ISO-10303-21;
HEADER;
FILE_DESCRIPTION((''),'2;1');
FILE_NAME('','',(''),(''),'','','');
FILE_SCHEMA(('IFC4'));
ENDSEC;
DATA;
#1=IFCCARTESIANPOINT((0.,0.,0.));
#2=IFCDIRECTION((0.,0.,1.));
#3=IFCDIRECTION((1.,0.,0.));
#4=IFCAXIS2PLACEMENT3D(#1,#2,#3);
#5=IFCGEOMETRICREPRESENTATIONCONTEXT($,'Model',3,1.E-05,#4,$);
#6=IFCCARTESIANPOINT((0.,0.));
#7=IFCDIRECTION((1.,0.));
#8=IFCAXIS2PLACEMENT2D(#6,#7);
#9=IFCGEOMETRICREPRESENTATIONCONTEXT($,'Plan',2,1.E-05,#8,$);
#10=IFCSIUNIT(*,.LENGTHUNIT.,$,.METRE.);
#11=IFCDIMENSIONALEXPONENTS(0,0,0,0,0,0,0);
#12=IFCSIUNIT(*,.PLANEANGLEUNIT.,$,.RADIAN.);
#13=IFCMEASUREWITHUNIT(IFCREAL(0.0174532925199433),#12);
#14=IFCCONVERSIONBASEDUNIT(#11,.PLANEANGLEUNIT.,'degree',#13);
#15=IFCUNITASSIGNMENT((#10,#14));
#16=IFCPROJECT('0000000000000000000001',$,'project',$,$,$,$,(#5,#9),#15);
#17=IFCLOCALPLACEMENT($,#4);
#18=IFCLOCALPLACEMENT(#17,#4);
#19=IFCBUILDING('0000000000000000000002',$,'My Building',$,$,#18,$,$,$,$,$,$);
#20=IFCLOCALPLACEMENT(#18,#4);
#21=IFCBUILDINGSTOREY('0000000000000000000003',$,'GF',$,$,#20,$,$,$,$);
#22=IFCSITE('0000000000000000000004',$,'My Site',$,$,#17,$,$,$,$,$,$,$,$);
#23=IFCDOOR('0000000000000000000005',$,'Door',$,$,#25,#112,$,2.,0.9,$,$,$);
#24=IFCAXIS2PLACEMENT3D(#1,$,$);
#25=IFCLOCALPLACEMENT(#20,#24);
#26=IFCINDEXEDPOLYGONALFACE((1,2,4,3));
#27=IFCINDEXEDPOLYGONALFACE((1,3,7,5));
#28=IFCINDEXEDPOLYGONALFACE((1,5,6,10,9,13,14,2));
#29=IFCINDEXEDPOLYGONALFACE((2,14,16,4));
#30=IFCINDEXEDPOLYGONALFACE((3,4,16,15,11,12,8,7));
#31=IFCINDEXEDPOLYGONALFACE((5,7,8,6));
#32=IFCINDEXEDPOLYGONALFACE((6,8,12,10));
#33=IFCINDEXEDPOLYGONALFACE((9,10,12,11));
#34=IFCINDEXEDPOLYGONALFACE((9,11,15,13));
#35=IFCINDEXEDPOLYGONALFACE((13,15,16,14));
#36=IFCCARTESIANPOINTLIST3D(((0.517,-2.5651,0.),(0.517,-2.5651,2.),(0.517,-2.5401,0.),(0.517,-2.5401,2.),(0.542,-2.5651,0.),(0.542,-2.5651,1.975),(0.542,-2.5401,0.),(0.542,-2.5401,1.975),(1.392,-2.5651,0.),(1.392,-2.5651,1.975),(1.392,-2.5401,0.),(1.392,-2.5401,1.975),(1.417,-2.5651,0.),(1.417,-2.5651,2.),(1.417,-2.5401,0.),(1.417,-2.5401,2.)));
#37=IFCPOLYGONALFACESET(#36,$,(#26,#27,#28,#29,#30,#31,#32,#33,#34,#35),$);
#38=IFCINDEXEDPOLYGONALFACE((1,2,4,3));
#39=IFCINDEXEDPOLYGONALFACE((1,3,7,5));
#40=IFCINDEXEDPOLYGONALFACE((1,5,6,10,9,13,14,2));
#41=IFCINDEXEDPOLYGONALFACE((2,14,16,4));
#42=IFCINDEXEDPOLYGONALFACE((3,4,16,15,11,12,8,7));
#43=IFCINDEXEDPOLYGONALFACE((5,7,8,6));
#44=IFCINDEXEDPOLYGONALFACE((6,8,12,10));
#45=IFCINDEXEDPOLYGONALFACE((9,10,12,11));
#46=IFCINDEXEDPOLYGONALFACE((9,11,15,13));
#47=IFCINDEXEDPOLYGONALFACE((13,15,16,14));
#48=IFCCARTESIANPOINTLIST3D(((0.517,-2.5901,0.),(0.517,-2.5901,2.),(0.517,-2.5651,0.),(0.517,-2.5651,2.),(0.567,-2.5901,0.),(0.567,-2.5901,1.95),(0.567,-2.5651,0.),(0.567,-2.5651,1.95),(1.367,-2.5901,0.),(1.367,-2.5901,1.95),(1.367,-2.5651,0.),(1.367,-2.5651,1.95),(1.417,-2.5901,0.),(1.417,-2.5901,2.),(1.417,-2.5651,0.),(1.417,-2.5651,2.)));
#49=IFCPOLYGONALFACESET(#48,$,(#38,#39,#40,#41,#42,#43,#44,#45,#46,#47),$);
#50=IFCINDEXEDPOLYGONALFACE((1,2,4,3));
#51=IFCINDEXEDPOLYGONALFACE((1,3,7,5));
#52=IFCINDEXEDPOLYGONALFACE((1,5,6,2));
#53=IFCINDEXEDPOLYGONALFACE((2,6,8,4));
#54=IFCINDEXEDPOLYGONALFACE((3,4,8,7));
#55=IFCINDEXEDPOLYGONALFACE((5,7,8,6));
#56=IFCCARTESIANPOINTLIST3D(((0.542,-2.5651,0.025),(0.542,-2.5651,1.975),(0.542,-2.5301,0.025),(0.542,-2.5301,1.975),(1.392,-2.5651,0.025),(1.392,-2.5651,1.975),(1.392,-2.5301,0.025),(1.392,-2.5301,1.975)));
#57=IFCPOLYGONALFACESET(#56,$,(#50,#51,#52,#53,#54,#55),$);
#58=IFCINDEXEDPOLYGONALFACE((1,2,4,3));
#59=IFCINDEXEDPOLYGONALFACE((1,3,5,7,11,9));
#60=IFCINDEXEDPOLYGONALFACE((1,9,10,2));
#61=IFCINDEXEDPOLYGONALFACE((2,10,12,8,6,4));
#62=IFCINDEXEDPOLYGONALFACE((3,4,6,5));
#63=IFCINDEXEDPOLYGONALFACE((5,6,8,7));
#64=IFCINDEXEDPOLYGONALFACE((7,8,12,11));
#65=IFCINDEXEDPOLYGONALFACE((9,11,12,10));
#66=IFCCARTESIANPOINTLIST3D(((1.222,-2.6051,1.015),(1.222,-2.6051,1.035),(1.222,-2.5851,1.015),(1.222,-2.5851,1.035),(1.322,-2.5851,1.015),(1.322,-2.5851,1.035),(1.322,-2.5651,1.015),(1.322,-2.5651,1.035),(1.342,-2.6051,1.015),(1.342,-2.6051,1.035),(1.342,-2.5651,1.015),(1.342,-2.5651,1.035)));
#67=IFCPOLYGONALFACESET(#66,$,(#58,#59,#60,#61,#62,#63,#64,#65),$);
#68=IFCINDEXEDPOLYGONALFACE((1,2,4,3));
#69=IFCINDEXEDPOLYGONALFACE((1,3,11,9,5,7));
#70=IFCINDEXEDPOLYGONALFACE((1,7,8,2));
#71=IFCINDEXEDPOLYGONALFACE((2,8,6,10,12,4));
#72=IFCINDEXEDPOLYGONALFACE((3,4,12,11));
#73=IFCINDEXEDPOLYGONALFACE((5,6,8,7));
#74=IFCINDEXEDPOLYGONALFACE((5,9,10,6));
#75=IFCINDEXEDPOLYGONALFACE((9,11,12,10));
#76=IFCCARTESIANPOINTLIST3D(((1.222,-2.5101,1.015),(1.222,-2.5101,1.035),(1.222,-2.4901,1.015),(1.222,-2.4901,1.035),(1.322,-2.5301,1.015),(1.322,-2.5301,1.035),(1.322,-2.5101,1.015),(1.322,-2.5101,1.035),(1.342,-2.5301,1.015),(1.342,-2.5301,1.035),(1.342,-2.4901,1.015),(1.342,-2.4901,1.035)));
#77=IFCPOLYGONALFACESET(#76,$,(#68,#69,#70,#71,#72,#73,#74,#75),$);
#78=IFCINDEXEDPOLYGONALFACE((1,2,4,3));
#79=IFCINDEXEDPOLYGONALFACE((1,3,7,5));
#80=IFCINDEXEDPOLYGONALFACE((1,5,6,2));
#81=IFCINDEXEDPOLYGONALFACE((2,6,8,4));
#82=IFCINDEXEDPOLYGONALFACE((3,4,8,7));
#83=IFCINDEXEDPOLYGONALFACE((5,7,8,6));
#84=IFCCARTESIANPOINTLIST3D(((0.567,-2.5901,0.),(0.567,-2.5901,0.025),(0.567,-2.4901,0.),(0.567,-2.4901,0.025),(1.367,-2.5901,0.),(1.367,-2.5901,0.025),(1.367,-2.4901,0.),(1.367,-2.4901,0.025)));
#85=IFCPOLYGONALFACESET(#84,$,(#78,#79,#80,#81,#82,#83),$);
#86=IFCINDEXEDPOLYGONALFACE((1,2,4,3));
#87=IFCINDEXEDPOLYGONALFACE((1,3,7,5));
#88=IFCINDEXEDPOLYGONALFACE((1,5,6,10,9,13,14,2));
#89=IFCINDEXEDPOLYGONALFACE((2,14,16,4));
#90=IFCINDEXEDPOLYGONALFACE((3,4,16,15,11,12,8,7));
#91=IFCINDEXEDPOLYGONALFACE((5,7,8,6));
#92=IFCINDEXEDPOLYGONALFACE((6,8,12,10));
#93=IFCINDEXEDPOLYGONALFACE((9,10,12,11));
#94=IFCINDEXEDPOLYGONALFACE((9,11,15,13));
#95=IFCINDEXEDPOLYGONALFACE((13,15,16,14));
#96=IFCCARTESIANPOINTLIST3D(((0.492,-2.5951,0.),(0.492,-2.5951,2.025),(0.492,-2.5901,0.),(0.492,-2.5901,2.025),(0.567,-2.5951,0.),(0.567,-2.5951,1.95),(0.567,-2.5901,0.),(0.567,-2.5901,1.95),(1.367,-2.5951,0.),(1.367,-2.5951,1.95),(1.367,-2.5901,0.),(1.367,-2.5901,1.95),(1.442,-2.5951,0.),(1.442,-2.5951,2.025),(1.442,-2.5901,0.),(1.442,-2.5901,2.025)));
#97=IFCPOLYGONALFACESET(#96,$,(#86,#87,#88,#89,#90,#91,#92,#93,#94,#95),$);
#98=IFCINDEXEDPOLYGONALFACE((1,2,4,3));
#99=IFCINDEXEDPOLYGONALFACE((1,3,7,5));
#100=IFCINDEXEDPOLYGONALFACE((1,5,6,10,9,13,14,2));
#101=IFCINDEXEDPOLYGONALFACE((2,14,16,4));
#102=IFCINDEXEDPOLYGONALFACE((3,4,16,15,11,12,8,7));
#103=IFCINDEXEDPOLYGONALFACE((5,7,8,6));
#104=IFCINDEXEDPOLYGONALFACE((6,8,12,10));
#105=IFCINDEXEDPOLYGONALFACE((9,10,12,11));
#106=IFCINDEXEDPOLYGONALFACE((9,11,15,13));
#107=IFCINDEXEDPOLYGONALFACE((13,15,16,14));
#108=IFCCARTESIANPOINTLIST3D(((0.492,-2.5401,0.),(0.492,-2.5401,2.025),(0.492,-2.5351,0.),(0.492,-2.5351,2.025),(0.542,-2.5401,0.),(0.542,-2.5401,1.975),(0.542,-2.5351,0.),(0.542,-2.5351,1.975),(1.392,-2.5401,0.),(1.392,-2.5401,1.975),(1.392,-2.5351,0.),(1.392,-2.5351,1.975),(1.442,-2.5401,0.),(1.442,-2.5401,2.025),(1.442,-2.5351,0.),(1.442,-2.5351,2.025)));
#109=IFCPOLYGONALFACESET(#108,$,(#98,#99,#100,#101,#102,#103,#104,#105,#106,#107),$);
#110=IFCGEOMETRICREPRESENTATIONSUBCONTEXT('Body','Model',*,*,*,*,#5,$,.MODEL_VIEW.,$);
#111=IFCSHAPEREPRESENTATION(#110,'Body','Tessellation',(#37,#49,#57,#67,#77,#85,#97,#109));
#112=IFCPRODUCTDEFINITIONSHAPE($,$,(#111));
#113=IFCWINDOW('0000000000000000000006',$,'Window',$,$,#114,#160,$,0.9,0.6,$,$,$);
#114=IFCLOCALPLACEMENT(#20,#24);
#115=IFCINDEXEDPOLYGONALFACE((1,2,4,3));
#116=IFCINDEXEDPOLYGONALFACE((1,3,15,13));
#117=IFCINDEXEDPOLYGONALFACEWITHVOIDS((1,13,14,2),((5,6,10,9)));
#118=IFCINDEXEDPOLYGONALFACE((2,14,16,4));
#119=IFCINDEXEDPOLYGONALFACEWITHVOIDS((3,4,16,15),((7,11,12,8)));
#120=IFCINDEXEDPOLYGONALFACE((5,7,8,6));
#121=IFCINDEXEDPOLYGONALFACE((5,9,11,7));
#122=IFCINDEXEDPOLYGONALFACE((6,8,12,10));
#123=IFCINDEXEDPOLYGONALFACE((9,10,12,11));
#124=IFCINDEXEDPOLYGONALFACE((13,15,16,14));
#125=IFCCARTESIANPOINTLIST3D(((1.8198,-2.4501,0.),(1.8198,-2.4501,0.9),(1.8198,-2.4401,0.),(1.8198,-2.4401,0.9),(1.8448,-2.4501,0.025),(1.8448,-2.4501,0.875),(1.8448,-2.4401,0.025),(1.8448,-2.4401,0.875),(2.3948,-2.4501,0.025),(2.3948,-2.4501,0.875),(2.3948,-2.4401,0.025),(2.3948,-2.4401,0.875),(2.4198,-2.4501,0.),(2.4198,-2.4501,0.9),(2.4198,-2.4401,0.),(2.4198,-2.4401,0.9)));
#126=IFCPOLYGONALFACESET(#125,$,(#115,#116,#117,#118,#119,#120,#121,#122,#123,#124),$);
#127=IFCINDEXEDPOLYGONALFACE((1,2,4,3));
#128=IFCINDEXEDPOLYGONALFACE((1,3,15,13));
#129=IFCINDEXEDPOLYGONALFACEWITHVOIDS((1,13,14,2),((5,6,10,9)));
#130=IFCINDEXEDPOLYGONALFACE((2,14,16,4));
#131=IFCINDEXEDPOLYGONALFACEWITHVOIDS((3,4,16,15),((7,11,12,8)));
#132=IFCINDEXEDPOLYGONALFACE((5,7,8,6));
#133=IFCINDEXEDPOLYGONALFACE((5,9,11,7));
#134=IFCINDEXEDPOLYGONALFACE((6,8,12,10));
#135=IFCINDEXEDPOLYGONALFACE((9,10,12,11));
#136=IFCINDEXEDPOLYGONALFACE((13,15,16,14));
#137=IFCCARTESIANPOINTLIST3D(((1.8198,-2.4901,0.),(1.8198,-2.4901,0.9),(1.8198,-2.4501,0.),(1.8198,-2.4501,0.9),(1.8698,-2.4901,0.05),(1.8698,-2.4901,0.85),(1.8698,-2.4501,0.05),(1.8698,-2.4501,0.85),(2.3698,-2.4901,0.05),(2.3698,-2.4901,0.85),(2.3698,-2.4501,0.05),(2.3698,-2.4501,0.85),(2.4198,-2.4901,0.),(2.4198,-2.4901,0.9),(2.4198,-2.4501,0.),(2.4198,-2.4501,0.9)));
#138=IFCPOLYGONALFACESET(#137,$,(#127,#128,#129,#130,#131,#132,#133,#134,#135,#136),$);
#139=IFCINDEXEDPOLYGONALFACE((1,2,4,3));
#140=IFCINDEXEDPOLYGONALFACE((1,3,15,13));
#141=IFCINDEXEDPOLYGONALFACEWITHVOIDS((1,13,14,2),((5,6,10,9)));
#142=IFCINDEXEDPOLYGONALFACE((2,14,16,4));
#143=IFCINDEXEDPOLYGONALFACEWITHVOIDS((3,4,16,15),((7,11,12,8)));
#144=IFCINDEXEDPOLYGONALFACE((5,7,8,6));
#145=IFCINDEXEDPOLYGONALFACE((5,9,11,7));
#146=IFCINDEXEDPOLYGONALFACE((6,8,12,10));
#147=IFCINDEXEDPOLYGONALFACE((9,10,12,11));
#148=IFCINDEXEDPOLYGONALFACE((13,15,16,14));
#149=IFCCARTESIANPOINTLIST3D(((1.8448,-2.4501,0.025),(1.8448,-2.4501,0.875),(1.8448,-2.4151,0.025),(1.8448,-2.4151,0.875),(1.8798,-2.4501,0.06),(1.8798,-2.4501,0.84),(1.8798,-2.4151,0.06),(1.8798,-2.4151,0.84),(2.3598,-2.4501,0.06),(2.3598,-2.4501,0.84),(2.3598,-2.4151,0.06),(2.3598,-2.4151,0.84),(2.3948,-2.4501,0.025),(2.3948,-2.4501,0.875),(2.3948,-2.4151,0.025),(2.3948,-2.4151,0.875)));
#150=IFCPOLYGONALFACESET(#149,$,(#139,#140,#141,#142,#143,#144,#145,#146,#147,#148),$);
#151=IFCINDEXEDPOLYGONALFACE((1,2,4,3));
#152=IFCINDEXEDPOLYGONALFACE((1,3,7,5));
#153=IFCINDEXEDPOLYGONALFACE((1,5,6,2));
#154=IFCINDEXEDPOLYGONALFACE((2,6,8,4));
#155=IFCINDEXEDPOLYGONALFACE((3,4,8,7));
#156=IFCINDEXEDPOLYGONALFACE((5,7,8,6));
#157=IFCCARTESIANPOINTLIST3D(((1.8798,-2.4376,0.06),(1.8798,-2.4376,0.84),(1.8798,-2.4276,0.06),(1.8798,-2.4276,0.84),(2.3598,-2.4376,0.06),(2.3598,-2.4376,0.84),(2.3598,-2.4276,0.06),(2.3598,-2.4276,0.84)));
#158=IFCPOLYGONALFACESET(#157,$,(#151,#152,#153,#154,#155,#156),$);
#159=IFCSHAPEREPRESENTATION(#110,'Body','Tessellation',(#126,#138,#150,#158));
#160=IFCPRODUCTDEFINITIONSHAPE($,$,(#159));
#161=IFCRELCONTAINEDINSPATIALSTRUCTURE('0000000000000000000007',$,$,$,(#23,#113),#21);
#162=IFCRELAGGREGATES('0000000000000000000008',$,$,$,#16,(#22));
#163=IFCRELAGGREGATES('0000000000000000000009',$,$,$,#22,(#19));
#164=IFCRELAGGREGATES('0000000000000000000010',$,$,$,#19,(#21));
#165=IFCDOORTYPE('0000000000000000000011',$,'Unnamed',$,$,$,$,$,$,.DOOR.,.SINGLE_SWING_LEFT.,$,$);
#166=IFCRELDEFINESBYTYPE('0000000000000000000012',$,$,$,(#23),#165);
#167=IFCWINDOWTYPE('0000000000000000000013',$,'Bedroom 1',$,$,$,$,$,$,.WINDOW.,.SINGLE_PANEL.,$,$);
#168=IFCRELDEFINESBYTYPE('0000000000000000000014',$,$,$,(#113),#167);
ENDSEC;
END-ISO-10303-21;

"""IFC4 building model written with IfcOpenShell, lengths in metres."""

from ifc_helpers import new_model, entity, si_unit, converted_unit, frame, origin_with_axes, origin_2d_with_axis, place, context, subcontext, project, spatial, line, indexed_curve, outline, extrude, shape, source, transform, mapped, type_object, type_shapes, element, save


model = new_model("IFC4")

# Units and contexts
model_context = context("Model", 3, precision=1e-05, world=origin_with_axes())
plan_context = context("Plan", 2, precision=1e-05, world=origin_2d_with_axis())
body_context_1 = subcontext(model_context, "Body", "Model", "MODEL_VIEW")
body_context_2 = subcontext(plan_context, "Body", "Plan", "PLAN_VIEW")
ifc_project = project(units=[si_unit("LENGTHUNIT", "METRE"), converted_unit("PLANEANGLEUNIT", "degree", entity("IfcReal", 0.0174532925199433), si_unit("PLANEANGLEUNIT", "RADIAN"), dimensions=[0, 0, 0, 0, 0, 0, 0])], contexts=[model_context, plan_context])

# Site, building, storey
site_placement = place(None, origin_with_axes())
site = spatial("IfcSite", under=ifc_project, at=site_placement, Name="My Site")
building_placement = place(site_placement, origin_with_axes())
building = spatial("IfcBuilding", under=site, at=building_placement, Name="My Building")
storey_placement = place(building_placement, origin_with_axes())
storey = spatial("IfcBuildingStorey", under=building, at=storey_placement, Name="GF")

# Shared definitions
door_type = type_object("IfcDoorType", Name="Unnamed", OperationType="SINGLE_SWING_LEFT", PredefinedType="DOOR")
shared_shape_1 = source(origin_with_axes(), body_context_1, "Body", "SweptSolid", [
    extrude(outline(indexed_curve([(0.0, 0.0), (0.0, 2.0), (0.9, 2.0), (0.9, 0.0), (0.875, 0.0), (0.875, 1.975), (0.025, 1.975), (0.025, 0.0)], segments=[line(1, 2, 3, 4, 5, 6, 7, 8, 1)])), frame((0.0, 0.025, 0.0), z_axis=(0.0, -1.0, 0.0), x_axis=(1.0, 0.0, 0.0)), (0.0, 0.0, -1.0), 0.025),
    extrude(outline(indexed_curve([(0.0, 0.0), (0.0, 2.0), (0.9, 2.0), (0.9, 0.0), (0.85, 0.0), (0.85, 1.95), (0.05, 1.95), (0.05, 0.0)], segments=[line(1, 2, 3, 4, 5, 6, 7, 8, 1)])), frame((0.0, 0.0, 0.0), z_axis=(0.0, -1.0, 0.0), x_axis=(1.0, 0.0, 0.0)), (0.0, 0.0, -1.0), 0.025),
    extrude(outline(indexed_curve([(0.0, 0.0), (0.85, 0.0), (0.85, 0.035), (0.0, 0.035)], segments=[line(1, 2, 3, 4, 1)])), frame((0.025, 0.025, 0.025), z_axis=(0.0, 0.0, 1.0), x_axis=(1.0, 0.0, 0.0)), (0.0, 0.0, 1.0), 1.95),
    extrude(outline(indexed_curve([(0.0, 0.0), (0.0, -0.04), (-0.12, -0.04), (-0.12, -0.02), (-0.02, -0.02), (-0.02, 0.0)], segments=[line(1, 2, 3, 4, 5, 6, 1)])), frame((0.825, 0.025, 1.015), z_axis=(0.0, 0.0, 1.0), x_axis=(1.0, 0.0, 0.0)), (0.0, 0.0, 1.0), 0.02),
    extrude(outline(indexed_curve([(0.0, 0.0), (0.0, 0.04), (-0.12, 0.04), (-0.12, 0.02), (-0.02, 0.02), (-0.02, 0.0)], segments=[line(1, 2, 3, 4, 5, 6, 1)])), frame((0.825, 0.06, 1.015), z_axis=(0.0, 0.0, 1.0), x_axis=(1.0, 0.0, 0.0)), (0.0, 0.0, 1.0), 0.02),
    extrude(outline(indexed_curve([(0.0, 0.0), (0.8, 0.0), (0.8, 0.1), (0.0, 0.1)], segments=[line(1, 2, 3, 4, 1)])), frame((0.05, 0.0, 0.0), z_axis=(0.0, 0.0, 1.0), x_axis=(1.0, 0.0, 0.0)), (0.0, 0.0, 1.0), 0.025),
    extrude(outline(indexed_curve([(0.0, 0.0), (0.0, 2.025), (0.95, 2.025), (0.95, 0.0), (0.875, 0.0), (0.875, 1.95), (0.075, 1.95), (0.075, 0.0)], segments=[line(1, 2, 3, 4, 5, 6, 7, 8, 1)])), frame((-0.025, -0.005, 0.0), z_axis=(0.0, -1.0, 0.0), x_axis=(1.0, 0.0, 0.0)), (0.0, 0.0, -1.0), 0.005),
    extrude(outline(indexed_curve([(0.0, 0.0), (0.0, 2.025), (0.95, 2.025), (0.95, 0.0), (0.9, 0.0), (0.9, 1.975), (0.05, 1.975), (0.05, 0.0)], segments=[line(1, 2, 3, 4, 5, 6, 7, 8, 1)])), frame((-0.025, 0.05, 0.0), z_axis=(0.0, -1.0, 0.0), x_axis=(1.0, 0.0, 0.0)), (0.0, 0.0, -1.0), 0.005),
])
shared_shape_2 = source(origin_with_axes(), body_context_2, "Body", "Curve2D", [
    entity("IfcIndexedPolyCurve", entity("IfcCartesianPointList2D", [[0.0, 0.0], [0.0, 0.05], [0.025, 0.05], [0.025, 0.025], [0.05, 0.025], [0.05, 0.0]]), [entity("IfcLineIndex", [1, 2, 3, 4, 5, 6, 1])]),
    entity("IfcIndexedPolyCurve", entity("IfcCartesianPointList2D", [[0.9, 0.0], [0.9, 0.05], [0.875, 0.05], [0.875, 0.025], [0.85, 0.025], [0.85, 0.0]]), [entity("IfcLineIndex", [1, 2, 3, 4, 5, 6, 1])]),
    entity("IfcTrimmedCurve", entity("IfcEllipse", entity("IfcAxis2Placement2D", entity("IfcCartesianPoint", [0.06, 0.05]), entity("IfcDirection", [1.0, 0.0])), 0.815, 0.85), [entity("IfcCartesianPoint", [0.875, 0.05])], [entity("IfcCartesianPoint", [0.06, 0.9])], True, "CARTESIAN"),
    entity("IfcIndexedPolyCurve", entity("IfcCartesianPointList2D", [[0.025, 0.05], [0.06, 0.05], [0.06, 0.9], [0.025, 0.9]]), [entity("IfcLineIndex", [1, 2, 3, 4, 1])]),
])
type_shapes(door_type, [shared_shape_1, shared_shape_2])

# Door
placement_1 = place(storey_placement, frame((0.2266, -2.5901, 0.0), z_axis=(0.0, 0.0, 1.0), x_axis=(1.0, 0.0, 0.0)))
placement_2 = place(placement_1, frame((0.2904, 0.0, 0.0), z_axis=(0.0, 0.0, 1.0), x_axis=(1.0, 0.0, 0.0)))
door_1_placement = place(placement_2, origin_with_axes())
element("IfcDoor", 1, at=door_1_placement, inside=storey, type_object=door_type, Name="Door", OverallHeight=2.0, OverallWidth=0.9, shapes=[
    shape(body_context_1, "Body", "MappedRepresentation", [mapped(shared_shape_1, transform((0.0, 0.0, 0.0), x_axis=(1.0, 0.0, 0.0), y_axis=(0.0, 1.0, 0.0), z_axis=(0.0, 0.0, 1.0), scale=1.0))]),
    shape(body_context_2, "Body", "MappedRepresentation", [mapped(shared_shape_2, transform((0.0, 0.0, 0.0), x_axis=(1.0, 0.0, 0.0), y_axis=(0.0, 1.0, 0.0), z_axis=(0.0, 0.0, 1.0), scale=1.0))]),
])

# Window
window_type_1 = type_object("IfcWindowType", Name="Bedroom 1", PartitioningType="SINGLE_PANEL", PredefinedType="WINDOW")
shared_shape_3 = source(origin_with_axes(), body_context_1, "Body", "SweptSolid", [
    extrude(outline(indexed_curve([(0.0, 0.0), (0.6, 0.0), (0.6, 0.9), (0.0, 0.9)], segments=[line(1, 2, 3, 4, 1)]), holes=[indexed_curve([(0.025, 0.025), (0.575, 0.025), (0.575, 0.875), (0.025, 0.875)], segments=[line(1, 2, 3, 4, 1)])]), frame((0.0, 0.09, 0.0), z_axis=(0.0, -1.0, 0.0), x_axis=(1.0, 0.0, 0.0)), (0.0, 0.0, -1.0), 0.01),
    extrude(outline(indexed_curve([(0.0, 0.0), (0.6, 0.0), (0.6, 0.9), (0.0, 0.9)], segments=[line(1, 2, 3, 4, 1)]), holes=[indexed_curve([(0.05, 0.05), (0.55, 0.05), (0.55, 0.85), (0.05, 0.85)], segments=[line(1, 2, 3, 4, 1)])]), frame((0.0, 0.05, 0.0), z_axis=(0.0, -1.0, 0.0), x_axis=(1.0, 0.0, 0.0)), (0.0, 0.0, -1.0), 0.04),
    extrude(outline(indexed_curve([(0.0, 0.0), (0.55, 0.0), (0.55, 0.85), (0.0, 0.85)], segments=[line(1, 2, 3, 4, 1)]), holes=[indexed_curve([(0.035, 0.035), (0.515, 0.035), (0.515, 0.815), (0.035, 0.815)], segments=[line(1, 2, 3, 4, 1)])]), frame((0.025, 0.09, 0.025), z_axis=(0.0, -1.0, 0.0), x_axis=(1.0, 0.0, 0.0)), (0.0, 0.0, -1.0), 0.035),
    extrude(outline(indexed_curve([(0.035, 0.035), (0.515, 0.035), (0.515, 0.815), (0.035, 0.815)], segments=[line(1, 2, 3, 4, 1)])), frame((0.025, 0.1025, 0.025), z_axis=(0.0, -1.0, 0.0), x_axis=(1.0, 0.0, 0.0)), (0.0, 0.0, -1.0), 0.01),
])
shared_shape_4 = source(origin_with_axes(), body_context_2, "Body", "Curve2D", [
    entity("IfcIndexedPolyCurve", entity("IfcCartesianPointList2D", [[0.05, 0.05], [0.55, 0.05]])),
    entity("IfcIndexedPolyCurve", entity("IfcCartesianPointList2D", [[0.0, 0.1], [0.025, 0.1], [0.025, 0.09], [0.05, 0.09], [0.05, 0.05], [0.0, 0.05]]), [entity("IfcLineIndex", [1, 2, 3, 4, 5, 6, 1])]),
    entity("IfcIndexedPolyCurve", entity("IfcCartesianPointList2D", [[0.6, 0.1], [0.575, 0.1], [0.575, 0.09], [0.55, 0.09], [0.55, 0.05], [0.6, 0.05]]), [entity("IfcLineIndex", [1, 2, 3, 4, 5, 6, 1])]),
    entity("IfcIndexedPolyCurve", entity("IfcCartesianPointList2D", [[0.025, 0.09], [0.06, 0.09], [0.06, 0.125], [0.025, 0.125]]), [entity("IfcLineIndex", [1, 2, 3, 4, 1])]),
    entity("IfcIndexedPolyCurve", entity("IfcCartesianPointList2D", [[0.575, 0.09], [0.54, 0.09], [0.54, 0.125], [0.575, 0.125]]), [entity("IfcLineIndex", [1, 2, 3, 4, 1])]),
    entity("IfcIndexedPolyCurve", entity("IfcCartesianPointList2D", [[0.06, 0.09], [0.54, 0.09]])),
    entity("IfcIndexedPolyCurve", entity("IfcCartesianPointList2D", [[0.06, 0.125], [0.54, 0.125]])),
    entity("IfcIndexedPolyCurve", entity("IfcCartesianPointList2D", [[0.06, 0.1075], [0.54, 0.1075]])),
])
type_shapes(window_type_1, [shared_shape_3, shared_shape_4])
window_1_placement = place(storey_placement, frame((1.8198, -2.5401, 0.0), z_axis=(0.0, 0.0, 1.0), x_axis=(1.0, 0.0, 0.0)))
element("IfcWindow", 2, at=window_1_placement, inside=storey, type_object=window_type_1, Name="Window", OverallHeight=0.9, OverallWidth=0.6, shapes=[
    shape(body_context_1, "Body", "MappedRepresentation", [mapped(shared_shape_3, transform((0.0, 0.0, 0.0), x_axis=(1.0, 0.0, 0.0), y_axis=(0.0, 1.0, 0.0), z_axis=(0.0, 0.0, 1.0), scale=1.0))]),
    shape(body_context_2, "Body", "MappedRepresentation", [mapped(shared_shape_4, transform((0.0, 0.0, 0.0), x_axis=(1.0, 0.0, 0.0), y_axis=(0.0, 1.0, 0.0), z_axis=(0.0, 0.0, 1.0), scale=1.0))]),
])

save(model, "model.ifc")
